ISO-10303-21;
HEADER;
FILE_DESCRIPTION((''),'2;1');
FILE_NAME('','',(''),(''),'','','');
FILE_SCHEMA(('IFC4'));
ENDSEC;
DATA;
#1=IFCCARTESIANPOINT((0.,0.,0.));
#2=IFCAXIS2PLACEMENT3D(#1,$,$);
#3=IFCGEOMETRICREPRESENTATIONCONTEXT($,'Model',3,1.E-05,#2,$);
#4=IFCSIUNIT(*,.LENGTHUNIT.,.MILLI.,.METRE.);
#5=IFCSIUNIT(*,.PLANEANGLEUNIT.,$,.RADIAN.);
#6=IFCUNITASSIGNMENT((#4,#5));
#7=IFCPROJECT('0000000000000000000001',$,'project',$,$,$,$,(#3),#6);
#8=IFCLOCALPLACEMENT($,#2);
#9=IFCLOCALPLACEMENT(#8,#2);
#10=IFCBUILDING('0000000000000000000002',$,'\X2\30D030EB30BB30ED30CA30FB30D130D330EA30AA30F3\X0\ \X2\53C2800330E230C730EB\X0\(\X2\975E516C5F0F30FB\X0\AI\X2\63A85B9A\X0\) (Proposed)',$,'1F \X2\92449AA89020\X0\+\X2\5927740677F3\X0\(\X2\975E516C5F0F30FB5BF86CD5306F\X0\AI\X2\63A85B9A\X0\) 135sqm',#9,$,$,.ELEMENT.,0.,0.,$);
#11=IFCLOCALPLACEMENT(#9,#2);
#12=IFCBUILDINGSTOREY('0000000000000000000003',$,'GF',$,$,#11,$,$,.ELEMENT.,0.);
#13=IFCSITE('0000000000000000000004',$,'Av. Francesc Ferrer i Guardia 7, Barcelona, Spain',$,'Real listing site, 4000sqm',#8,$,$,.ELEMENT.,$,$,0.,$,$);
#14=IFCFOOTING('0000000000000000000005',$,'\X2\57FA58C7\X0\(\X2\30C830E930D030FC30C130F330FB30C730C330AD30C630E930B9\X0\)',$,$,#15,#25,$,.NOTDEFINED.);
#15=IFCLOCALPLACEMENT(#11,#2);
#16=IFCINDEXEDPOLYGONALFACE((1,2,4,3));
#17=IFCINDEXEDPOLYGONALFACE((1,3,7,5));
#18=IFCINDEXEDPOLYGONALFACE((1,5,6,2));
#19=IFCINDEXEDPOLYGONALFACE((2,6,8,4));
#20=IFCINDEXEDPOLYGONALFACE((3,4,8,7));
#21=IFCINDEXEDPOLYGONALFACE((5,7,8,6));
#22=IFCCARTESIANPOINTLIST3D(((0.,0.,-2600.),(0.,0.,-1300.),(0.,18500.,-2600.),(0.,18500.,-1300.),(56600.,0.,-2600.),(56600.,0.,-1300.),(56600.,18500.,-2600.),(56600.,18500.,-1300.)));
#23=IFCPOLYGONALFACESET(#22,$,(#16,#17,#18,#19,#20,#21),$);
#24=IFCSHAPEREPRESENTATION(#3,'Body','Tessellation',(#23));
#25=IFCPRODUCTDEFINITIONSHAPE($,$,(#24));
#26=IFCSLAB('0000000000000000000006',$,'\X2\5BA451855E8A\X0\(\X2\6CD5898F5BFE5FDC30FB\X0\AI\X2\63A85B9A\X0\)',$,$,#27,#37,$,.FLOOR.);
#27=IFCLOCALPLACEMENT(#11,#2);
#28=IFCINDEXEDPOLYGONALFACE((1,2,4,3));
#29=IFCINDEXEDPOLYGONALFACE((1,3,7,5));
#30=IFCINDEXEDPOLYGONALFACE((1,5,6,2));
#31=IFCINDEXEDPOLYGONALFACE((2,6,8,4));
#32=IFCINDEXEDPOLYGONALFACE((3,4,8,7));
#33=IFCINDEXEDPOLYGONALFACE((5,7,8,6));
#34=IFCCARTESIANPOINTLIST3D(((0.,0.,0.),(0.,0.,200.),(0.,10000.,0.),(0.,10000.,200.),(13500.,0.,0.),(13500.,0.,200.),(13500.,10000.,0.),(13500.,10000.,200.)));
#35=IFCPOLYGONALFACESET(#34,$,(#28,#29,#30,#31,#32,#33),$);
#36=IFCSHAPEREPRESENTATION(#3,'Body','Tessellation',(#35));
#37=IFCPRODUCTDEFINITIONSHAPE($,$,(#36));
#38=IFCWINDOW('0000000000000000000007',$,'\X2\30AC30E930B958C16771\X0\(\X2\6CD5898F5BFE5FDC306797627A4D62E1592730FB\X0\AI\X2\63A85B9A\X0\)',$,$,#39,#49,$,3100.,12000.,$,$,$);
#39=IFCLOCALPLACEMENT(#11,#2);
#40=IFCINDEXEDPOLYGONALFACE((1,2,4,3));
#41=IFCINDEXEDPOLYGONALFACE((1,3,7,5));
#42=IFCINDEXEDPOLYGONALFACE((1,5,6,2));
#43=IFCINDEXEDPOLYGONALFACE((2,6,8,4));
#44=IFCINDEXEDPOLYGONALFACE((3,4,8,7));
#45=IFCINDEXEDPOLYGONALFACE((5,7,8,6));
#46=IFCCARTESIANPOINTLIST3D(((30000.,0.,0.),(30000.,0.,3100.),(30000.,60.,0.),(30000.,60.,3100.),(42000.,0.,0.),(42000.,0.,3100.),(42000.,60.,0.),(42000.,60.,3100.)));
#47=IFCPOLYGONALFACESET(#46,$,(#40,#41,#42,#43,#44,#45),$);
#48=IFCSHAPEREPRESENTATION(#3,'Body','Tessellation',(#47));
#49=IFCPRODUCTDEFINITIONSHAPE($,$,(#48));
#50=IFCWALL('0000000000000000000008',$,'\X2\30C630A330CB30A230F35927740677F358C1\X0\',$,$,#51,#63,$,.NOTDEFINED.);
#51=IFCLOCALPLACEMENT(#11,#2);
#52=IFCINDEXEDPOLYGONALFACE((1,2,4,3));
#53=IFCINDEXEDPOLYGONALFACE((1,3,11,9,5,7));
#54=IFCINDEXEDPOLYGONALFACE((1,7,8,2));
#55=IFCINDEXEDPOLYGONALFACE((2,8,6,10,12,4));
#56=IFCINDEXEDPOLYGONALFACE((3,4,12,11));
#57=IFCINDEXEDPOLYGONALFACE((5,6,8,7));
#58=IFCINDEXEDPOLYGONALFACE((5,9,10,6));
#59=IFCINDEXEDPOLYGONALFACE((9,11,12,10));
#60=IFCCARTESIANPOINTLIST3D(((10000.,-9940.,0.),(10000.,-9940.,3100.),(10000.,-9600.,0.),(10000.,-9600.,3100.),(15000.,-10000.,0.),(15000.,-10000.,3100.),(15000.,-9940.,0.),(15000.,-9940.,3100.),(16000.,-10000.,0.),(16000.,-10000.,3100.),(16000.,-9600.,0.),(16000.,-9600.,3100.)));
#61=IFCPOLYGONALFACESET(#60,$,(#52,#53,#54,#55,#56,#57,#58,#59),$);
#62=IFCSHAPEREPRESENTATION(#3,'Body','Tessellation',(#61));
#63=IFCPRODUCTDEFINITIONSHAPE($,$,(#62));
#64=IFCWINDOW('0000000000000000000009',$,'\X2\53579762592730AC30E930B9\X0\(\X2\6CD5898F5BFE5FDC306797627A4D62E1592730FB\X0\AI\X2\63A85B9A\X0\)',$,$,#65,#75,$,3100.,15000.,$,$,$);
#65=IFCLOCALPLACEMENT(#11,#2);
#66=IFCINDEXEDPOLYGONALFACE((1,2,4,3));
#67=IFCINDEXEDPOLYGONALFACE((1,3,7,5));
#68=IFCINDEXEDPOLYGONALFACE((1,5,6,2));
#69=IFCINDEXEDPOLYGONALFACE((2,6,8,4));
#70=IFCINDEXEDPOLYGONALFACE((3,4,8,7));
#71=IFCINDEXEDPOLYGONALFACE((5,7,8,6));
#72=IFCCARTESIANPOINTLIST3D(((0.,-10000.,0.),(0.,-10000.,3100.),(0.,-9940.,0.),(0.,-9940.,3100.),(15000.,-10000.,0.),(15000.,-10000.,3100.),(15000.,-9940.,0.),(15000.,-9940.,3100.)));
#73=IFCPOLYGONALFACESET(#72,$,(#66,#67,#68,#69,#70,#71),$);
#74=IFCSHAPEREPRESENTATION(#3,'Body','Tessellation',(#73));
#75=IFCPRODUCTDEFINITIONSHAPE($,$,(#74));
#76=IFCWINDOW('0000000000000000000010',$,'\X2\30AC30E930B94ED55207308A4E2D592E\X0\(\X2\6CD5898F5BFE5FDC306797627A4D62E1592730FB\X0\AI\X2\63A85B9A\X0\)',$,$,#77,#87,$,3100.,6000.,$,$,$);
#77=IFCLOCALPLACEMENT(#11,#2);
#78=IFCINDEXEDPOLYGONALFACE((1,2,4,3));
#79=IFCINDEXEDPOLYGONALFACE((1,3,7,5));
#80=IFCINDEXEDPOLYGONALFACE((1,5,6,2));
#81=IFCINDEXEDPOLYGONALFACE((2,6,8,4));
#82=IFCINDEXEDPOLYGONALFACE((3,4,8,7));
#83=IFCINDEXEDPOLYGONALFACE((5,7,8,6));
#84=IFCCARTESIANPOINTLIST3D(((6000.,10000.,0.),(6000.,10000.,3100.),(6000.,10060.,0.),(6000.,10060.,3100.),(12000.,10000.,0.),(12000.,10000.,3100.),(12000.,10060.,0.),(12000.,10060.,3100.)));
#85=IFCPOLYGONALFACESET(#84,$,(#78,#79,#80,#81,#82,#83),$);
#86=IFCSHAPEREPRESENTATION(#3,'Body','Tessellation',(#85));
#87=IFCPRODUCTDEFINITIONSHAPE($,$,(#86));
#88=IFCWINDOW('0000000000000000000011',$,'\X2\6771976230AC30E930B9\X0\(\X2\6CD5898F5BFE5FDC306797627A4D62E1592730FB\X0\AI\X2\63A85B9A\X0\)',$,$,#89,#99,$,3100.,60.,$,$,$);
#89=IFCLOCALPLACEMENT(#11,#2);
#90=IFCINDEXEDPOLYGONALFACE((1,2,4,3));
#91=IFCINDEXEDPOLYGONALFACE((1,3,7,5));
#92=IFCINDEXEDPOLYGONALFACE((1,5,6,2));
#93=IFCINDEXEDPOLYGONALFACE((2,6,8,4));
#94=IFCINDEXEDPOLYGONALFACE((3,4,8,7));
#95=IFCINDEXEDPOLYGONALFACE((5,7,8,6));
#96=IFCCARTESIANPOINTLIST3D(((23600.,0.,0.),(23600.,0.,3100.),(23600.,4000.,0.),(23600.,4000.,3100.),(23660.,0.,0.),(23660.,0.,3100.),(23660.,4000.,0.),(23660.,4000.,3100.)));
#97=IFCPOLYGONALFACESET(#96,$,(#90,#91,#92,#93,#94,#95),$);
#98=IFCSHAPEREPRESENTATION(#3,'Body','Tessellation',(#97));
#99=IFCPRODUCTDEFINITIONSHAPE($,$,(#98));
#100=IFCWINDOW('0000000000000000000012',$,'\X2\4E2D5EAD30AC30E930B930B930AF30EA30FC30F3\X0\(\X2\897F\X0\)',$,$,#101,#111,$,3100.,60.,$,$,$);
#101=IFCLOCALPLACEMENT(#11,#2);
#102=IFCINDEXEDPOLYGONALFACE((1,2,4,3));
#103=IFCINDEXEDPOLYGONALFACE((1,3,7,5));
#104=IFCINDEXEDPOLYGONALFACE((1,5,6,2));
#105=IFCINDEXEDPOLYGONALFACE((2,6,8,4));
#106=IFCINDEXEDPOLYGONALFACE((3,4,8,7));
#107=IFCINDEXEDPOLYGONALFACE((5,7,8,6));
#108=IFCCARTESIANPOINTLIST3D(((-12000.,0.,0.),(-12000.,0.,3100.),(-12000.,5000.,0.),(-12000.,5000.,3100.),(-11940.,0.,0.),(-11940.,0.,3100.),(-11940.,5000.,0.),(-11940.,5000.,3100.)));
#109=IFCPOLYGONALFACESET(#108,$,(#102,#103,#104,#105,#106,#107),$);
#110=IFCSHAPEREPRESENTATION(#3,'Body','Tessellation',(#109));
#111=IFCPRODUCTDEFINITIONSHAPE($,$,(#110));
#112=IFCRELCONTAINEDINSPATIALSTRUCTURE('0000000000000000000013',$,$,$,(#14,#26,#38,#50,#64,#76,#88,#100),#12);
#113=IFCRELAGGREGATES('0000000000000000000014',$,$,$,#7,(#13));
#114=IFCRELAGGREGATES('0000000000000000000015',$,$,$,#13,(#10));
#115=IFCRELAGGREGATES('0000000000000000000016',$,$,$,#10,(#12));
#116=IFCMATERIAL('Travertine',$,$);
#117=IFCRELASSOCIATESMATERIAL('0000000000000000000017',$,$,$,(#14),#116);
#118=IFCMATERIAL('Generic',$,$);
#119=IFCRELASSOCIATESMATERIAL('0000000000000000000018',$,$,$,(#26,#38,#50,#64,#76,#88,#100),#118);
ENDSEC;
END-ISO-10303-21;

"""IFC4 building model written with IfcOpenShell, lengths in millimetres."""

from ifc_helpers import new_model, si_unit, frame, frame_2d, origin, place, context, project, spatial, rectangle, extrude, material, element, fill, save


model = new_model("IFC4")

# Units and contexts
model_context = context("Model", 3, precision=1e-05, world=origin())
ifc_project = project(units=[si_unit("LENGTHUNIT", "METRE", prefix="MILLI"), si_unit("PLANEANGLEUNIT", "RADIAN")], contexts=[model_context])

# Site, building, storey
site_placement = place(None, origin())
site = spatial("IfcSite", under=ifc_project, at=site_placement, Name="Av. Francesc Ferrer i Guardia 7, Barcelona, Spain", ObjectType="Real listing site, 4000sqm", CompositionType="ELEMENT", RefElevation=0.0)
building_placement = place(site_placement, origin())
building = spatial("IfcBuilding", under=site, at=building_placement, Name="バルセロナ・パビリオン 参考モデル(非公式・AI推定) (Proposed)", ObjectType="1F 鉄骨造+大理石(非公式・寸法はAI推定) 135sqm", CompositionType="ELEMENT", ElevationOfRefHeight=0.0, ElevationOfTerrain=0.0)
storey_placement = place(building_placement, origin())
storey = spatial("IfcBuildingStorey", under=building, at=storey_placement, Name="GF", CompositionType="ELEMENT", Elevation=0.0)

# Footing
ifc_material_1 = material(Name="Travertine")
footing_placement = place(storey_placement, frame((0.0, 0.0, -1300.0)))
element("IfcFooting", 1, at=footing_placement, inside=storey, material=ifc_material_1, Name="基壇(トラバーチン・デッキテラス)", PredefinedType="NOTDEFINED", context=model_context, shape_type="SweptSolid", body=[
    extrude(rectangle(XDim=56600.0, YDim=18500.0, at=frame_2d((28300.0, 9250.0))), frame((0.0, 0.0, -1300.0)), (0.0, 0.0, 1.0), 1300.0),
])

# Shared definitions
ifc_material_2 = material(Name="Generic")

# Slab
slab_1_placement = place(storey_placement, origin())
element("IfcSlab", 2, at=slab_1_placement, inside=storey, material=ifc_material_2, Name="室内床(法規対応・AI推定)", PredefinedType="FLOOR", context=model_context, shape_type="SweptSolid", body=[
    extrude(rectangle(XDim=13500.0, YDim=10000.0, at=frame_2d((6750.0, 5000.0))), origin(), (0.0, 0.0, 1.0), 200.0),
])

# Window
window_1_placement = place(storey_placement, frame((15000.0, 0.0, 0.0)))
element("IfcWindow", 3, at=window_1_placement, inside=storey, material=ifc_material_2, Name="ガラス壁東(法規対応で面積拡大・AI推定)", OverallHeight=3100.0, OverallWidth=12000.0, context=model_context, shape_type="SweptSolid", body=[
    extrude(rectangle(XDim=12000.0, YDim=60.0, at=frame_2d((6000.0, 30.0))), frame((15000.0, 0.0, 0.0)), (0.0, 0.0, 1.0), 3100.0),
])

# Wall, opening, window
wall_1_placement = place(storey_placement, frame((5000.0, -5000.0, 0.0)))
wall_1 = element("IfcWall", 4, at=wall_1_placement, inside=storey, material=ifc_material_2, Name="ティニアン大理石壁", PredefinedType="NOTDEFINED", context=model_context, shape_type="SweptSolid", body=[
    extrude(rectangle(XDim=6000.0, YDim=400.0, at=frame_2d((3000.0, 200.0))), frame((5000.0, -5000.0, 0.0)), (0.0, 0.0, 1.0), 3100.0),
])
opening_1_placement = place(storey_placement, frame((0.0, -5000.0, 0.0)))
opening_1 = element("IfcOpeningElement", 5, at=opening_1_placement, cuts=wall_1, PredefinedType="NOTDEFINED", context=model_context, shape_type="SweptSolid", body=[
    extrude(rectangle(XDim=15000.0, YDim=60.0, at=frame_2d((7500.0, 30.0))), frame((0.0, -5000.0, 0.0)), (0.0, 0.0, 1.0), 3100.0),
])
window_2_placement = place(storey_placement, frame((0.0, -5000.0, 0.0)))
window_2 = element("IfcWindow", 6, at=window_2_placement, inside=storey, material=ifc_material_2, Name="南面大ガラス(法規対応で面積拡大・AI推定)", OverallHeight=3100.0, OverallWidth=15000.0, context=model_context, shape_type="SweptSolid", body=[
    extrude(rectangle(XDim=15000.0, YDim=60.0, at=frame_2d((7500.0, 30.0))), frame((0.0, -5000.0, 0.0)), (0.0, 0.0, 1.0), 3100.0),
])
fill(opening_1, window_2)

# Windows
window_3_placement = place(storey_placement, frame((3000.0, 5000.0, 0.0)))
element("IfcWindow", 7, at=window_3_placement, inside=storey, material=ifc_material_2, Name="ガラス仕切り中央(法規対応で面積拡大・AI推定)", OverallHeight=3100.0, OverallWidth=6000.0, context=model_context, shape_type="SweptSolid", body=[
    extrude(rectangle(XDim=6000.0, YDim=60.0, at=frame_2d((3000.0, 30.0))), frame((3000.0, 5000.0, 0.0)), (0.0, 0.0, 1.0), 3100.0),
])
window_4_placement = place(storey_placement, frame((11800.0, 0.0, 0.0)))
element("IfcWindow", 8, at=window_4_placement, inside=storey, material=ifc_material_2, Name="東面ガラス(法規対応で面積拡大・AI推定)", OverallHeight=3100.0, OverallWidth=60.0, context=model_context, shape_type="SweptSolid", body=[
    extrude(rectangle(XDim=60.0, YDim=4000.0, at=frame_2d((30.0, 2000.0))), frame((11800.0, 0.0, 0.0)), (0.0, 0.0, 1.0), 3100.0),
])

# Window
window_5_placement = place(storey_placement, frame((-6000.0, 0.0, 0.0)))
element("IfcWindow", 9, at=window_5_placement, inside=storey, material=ifc_material_2, Name="中庭ガラススクリーン(西)", OverallHeight=3100.0, OverallWidth=60.0, context=model_context, shape_type="SweptSolid", body=[
    extrude(rectangle(XDim=60.0, YDim=5000.0, at=frame_2d((30.0, 2500.0))), frame((-6000.0, 0.0, 0.0)), (0.0, 0.0, 1.0), 3100.0),
])

save(model, "model.ifc")
